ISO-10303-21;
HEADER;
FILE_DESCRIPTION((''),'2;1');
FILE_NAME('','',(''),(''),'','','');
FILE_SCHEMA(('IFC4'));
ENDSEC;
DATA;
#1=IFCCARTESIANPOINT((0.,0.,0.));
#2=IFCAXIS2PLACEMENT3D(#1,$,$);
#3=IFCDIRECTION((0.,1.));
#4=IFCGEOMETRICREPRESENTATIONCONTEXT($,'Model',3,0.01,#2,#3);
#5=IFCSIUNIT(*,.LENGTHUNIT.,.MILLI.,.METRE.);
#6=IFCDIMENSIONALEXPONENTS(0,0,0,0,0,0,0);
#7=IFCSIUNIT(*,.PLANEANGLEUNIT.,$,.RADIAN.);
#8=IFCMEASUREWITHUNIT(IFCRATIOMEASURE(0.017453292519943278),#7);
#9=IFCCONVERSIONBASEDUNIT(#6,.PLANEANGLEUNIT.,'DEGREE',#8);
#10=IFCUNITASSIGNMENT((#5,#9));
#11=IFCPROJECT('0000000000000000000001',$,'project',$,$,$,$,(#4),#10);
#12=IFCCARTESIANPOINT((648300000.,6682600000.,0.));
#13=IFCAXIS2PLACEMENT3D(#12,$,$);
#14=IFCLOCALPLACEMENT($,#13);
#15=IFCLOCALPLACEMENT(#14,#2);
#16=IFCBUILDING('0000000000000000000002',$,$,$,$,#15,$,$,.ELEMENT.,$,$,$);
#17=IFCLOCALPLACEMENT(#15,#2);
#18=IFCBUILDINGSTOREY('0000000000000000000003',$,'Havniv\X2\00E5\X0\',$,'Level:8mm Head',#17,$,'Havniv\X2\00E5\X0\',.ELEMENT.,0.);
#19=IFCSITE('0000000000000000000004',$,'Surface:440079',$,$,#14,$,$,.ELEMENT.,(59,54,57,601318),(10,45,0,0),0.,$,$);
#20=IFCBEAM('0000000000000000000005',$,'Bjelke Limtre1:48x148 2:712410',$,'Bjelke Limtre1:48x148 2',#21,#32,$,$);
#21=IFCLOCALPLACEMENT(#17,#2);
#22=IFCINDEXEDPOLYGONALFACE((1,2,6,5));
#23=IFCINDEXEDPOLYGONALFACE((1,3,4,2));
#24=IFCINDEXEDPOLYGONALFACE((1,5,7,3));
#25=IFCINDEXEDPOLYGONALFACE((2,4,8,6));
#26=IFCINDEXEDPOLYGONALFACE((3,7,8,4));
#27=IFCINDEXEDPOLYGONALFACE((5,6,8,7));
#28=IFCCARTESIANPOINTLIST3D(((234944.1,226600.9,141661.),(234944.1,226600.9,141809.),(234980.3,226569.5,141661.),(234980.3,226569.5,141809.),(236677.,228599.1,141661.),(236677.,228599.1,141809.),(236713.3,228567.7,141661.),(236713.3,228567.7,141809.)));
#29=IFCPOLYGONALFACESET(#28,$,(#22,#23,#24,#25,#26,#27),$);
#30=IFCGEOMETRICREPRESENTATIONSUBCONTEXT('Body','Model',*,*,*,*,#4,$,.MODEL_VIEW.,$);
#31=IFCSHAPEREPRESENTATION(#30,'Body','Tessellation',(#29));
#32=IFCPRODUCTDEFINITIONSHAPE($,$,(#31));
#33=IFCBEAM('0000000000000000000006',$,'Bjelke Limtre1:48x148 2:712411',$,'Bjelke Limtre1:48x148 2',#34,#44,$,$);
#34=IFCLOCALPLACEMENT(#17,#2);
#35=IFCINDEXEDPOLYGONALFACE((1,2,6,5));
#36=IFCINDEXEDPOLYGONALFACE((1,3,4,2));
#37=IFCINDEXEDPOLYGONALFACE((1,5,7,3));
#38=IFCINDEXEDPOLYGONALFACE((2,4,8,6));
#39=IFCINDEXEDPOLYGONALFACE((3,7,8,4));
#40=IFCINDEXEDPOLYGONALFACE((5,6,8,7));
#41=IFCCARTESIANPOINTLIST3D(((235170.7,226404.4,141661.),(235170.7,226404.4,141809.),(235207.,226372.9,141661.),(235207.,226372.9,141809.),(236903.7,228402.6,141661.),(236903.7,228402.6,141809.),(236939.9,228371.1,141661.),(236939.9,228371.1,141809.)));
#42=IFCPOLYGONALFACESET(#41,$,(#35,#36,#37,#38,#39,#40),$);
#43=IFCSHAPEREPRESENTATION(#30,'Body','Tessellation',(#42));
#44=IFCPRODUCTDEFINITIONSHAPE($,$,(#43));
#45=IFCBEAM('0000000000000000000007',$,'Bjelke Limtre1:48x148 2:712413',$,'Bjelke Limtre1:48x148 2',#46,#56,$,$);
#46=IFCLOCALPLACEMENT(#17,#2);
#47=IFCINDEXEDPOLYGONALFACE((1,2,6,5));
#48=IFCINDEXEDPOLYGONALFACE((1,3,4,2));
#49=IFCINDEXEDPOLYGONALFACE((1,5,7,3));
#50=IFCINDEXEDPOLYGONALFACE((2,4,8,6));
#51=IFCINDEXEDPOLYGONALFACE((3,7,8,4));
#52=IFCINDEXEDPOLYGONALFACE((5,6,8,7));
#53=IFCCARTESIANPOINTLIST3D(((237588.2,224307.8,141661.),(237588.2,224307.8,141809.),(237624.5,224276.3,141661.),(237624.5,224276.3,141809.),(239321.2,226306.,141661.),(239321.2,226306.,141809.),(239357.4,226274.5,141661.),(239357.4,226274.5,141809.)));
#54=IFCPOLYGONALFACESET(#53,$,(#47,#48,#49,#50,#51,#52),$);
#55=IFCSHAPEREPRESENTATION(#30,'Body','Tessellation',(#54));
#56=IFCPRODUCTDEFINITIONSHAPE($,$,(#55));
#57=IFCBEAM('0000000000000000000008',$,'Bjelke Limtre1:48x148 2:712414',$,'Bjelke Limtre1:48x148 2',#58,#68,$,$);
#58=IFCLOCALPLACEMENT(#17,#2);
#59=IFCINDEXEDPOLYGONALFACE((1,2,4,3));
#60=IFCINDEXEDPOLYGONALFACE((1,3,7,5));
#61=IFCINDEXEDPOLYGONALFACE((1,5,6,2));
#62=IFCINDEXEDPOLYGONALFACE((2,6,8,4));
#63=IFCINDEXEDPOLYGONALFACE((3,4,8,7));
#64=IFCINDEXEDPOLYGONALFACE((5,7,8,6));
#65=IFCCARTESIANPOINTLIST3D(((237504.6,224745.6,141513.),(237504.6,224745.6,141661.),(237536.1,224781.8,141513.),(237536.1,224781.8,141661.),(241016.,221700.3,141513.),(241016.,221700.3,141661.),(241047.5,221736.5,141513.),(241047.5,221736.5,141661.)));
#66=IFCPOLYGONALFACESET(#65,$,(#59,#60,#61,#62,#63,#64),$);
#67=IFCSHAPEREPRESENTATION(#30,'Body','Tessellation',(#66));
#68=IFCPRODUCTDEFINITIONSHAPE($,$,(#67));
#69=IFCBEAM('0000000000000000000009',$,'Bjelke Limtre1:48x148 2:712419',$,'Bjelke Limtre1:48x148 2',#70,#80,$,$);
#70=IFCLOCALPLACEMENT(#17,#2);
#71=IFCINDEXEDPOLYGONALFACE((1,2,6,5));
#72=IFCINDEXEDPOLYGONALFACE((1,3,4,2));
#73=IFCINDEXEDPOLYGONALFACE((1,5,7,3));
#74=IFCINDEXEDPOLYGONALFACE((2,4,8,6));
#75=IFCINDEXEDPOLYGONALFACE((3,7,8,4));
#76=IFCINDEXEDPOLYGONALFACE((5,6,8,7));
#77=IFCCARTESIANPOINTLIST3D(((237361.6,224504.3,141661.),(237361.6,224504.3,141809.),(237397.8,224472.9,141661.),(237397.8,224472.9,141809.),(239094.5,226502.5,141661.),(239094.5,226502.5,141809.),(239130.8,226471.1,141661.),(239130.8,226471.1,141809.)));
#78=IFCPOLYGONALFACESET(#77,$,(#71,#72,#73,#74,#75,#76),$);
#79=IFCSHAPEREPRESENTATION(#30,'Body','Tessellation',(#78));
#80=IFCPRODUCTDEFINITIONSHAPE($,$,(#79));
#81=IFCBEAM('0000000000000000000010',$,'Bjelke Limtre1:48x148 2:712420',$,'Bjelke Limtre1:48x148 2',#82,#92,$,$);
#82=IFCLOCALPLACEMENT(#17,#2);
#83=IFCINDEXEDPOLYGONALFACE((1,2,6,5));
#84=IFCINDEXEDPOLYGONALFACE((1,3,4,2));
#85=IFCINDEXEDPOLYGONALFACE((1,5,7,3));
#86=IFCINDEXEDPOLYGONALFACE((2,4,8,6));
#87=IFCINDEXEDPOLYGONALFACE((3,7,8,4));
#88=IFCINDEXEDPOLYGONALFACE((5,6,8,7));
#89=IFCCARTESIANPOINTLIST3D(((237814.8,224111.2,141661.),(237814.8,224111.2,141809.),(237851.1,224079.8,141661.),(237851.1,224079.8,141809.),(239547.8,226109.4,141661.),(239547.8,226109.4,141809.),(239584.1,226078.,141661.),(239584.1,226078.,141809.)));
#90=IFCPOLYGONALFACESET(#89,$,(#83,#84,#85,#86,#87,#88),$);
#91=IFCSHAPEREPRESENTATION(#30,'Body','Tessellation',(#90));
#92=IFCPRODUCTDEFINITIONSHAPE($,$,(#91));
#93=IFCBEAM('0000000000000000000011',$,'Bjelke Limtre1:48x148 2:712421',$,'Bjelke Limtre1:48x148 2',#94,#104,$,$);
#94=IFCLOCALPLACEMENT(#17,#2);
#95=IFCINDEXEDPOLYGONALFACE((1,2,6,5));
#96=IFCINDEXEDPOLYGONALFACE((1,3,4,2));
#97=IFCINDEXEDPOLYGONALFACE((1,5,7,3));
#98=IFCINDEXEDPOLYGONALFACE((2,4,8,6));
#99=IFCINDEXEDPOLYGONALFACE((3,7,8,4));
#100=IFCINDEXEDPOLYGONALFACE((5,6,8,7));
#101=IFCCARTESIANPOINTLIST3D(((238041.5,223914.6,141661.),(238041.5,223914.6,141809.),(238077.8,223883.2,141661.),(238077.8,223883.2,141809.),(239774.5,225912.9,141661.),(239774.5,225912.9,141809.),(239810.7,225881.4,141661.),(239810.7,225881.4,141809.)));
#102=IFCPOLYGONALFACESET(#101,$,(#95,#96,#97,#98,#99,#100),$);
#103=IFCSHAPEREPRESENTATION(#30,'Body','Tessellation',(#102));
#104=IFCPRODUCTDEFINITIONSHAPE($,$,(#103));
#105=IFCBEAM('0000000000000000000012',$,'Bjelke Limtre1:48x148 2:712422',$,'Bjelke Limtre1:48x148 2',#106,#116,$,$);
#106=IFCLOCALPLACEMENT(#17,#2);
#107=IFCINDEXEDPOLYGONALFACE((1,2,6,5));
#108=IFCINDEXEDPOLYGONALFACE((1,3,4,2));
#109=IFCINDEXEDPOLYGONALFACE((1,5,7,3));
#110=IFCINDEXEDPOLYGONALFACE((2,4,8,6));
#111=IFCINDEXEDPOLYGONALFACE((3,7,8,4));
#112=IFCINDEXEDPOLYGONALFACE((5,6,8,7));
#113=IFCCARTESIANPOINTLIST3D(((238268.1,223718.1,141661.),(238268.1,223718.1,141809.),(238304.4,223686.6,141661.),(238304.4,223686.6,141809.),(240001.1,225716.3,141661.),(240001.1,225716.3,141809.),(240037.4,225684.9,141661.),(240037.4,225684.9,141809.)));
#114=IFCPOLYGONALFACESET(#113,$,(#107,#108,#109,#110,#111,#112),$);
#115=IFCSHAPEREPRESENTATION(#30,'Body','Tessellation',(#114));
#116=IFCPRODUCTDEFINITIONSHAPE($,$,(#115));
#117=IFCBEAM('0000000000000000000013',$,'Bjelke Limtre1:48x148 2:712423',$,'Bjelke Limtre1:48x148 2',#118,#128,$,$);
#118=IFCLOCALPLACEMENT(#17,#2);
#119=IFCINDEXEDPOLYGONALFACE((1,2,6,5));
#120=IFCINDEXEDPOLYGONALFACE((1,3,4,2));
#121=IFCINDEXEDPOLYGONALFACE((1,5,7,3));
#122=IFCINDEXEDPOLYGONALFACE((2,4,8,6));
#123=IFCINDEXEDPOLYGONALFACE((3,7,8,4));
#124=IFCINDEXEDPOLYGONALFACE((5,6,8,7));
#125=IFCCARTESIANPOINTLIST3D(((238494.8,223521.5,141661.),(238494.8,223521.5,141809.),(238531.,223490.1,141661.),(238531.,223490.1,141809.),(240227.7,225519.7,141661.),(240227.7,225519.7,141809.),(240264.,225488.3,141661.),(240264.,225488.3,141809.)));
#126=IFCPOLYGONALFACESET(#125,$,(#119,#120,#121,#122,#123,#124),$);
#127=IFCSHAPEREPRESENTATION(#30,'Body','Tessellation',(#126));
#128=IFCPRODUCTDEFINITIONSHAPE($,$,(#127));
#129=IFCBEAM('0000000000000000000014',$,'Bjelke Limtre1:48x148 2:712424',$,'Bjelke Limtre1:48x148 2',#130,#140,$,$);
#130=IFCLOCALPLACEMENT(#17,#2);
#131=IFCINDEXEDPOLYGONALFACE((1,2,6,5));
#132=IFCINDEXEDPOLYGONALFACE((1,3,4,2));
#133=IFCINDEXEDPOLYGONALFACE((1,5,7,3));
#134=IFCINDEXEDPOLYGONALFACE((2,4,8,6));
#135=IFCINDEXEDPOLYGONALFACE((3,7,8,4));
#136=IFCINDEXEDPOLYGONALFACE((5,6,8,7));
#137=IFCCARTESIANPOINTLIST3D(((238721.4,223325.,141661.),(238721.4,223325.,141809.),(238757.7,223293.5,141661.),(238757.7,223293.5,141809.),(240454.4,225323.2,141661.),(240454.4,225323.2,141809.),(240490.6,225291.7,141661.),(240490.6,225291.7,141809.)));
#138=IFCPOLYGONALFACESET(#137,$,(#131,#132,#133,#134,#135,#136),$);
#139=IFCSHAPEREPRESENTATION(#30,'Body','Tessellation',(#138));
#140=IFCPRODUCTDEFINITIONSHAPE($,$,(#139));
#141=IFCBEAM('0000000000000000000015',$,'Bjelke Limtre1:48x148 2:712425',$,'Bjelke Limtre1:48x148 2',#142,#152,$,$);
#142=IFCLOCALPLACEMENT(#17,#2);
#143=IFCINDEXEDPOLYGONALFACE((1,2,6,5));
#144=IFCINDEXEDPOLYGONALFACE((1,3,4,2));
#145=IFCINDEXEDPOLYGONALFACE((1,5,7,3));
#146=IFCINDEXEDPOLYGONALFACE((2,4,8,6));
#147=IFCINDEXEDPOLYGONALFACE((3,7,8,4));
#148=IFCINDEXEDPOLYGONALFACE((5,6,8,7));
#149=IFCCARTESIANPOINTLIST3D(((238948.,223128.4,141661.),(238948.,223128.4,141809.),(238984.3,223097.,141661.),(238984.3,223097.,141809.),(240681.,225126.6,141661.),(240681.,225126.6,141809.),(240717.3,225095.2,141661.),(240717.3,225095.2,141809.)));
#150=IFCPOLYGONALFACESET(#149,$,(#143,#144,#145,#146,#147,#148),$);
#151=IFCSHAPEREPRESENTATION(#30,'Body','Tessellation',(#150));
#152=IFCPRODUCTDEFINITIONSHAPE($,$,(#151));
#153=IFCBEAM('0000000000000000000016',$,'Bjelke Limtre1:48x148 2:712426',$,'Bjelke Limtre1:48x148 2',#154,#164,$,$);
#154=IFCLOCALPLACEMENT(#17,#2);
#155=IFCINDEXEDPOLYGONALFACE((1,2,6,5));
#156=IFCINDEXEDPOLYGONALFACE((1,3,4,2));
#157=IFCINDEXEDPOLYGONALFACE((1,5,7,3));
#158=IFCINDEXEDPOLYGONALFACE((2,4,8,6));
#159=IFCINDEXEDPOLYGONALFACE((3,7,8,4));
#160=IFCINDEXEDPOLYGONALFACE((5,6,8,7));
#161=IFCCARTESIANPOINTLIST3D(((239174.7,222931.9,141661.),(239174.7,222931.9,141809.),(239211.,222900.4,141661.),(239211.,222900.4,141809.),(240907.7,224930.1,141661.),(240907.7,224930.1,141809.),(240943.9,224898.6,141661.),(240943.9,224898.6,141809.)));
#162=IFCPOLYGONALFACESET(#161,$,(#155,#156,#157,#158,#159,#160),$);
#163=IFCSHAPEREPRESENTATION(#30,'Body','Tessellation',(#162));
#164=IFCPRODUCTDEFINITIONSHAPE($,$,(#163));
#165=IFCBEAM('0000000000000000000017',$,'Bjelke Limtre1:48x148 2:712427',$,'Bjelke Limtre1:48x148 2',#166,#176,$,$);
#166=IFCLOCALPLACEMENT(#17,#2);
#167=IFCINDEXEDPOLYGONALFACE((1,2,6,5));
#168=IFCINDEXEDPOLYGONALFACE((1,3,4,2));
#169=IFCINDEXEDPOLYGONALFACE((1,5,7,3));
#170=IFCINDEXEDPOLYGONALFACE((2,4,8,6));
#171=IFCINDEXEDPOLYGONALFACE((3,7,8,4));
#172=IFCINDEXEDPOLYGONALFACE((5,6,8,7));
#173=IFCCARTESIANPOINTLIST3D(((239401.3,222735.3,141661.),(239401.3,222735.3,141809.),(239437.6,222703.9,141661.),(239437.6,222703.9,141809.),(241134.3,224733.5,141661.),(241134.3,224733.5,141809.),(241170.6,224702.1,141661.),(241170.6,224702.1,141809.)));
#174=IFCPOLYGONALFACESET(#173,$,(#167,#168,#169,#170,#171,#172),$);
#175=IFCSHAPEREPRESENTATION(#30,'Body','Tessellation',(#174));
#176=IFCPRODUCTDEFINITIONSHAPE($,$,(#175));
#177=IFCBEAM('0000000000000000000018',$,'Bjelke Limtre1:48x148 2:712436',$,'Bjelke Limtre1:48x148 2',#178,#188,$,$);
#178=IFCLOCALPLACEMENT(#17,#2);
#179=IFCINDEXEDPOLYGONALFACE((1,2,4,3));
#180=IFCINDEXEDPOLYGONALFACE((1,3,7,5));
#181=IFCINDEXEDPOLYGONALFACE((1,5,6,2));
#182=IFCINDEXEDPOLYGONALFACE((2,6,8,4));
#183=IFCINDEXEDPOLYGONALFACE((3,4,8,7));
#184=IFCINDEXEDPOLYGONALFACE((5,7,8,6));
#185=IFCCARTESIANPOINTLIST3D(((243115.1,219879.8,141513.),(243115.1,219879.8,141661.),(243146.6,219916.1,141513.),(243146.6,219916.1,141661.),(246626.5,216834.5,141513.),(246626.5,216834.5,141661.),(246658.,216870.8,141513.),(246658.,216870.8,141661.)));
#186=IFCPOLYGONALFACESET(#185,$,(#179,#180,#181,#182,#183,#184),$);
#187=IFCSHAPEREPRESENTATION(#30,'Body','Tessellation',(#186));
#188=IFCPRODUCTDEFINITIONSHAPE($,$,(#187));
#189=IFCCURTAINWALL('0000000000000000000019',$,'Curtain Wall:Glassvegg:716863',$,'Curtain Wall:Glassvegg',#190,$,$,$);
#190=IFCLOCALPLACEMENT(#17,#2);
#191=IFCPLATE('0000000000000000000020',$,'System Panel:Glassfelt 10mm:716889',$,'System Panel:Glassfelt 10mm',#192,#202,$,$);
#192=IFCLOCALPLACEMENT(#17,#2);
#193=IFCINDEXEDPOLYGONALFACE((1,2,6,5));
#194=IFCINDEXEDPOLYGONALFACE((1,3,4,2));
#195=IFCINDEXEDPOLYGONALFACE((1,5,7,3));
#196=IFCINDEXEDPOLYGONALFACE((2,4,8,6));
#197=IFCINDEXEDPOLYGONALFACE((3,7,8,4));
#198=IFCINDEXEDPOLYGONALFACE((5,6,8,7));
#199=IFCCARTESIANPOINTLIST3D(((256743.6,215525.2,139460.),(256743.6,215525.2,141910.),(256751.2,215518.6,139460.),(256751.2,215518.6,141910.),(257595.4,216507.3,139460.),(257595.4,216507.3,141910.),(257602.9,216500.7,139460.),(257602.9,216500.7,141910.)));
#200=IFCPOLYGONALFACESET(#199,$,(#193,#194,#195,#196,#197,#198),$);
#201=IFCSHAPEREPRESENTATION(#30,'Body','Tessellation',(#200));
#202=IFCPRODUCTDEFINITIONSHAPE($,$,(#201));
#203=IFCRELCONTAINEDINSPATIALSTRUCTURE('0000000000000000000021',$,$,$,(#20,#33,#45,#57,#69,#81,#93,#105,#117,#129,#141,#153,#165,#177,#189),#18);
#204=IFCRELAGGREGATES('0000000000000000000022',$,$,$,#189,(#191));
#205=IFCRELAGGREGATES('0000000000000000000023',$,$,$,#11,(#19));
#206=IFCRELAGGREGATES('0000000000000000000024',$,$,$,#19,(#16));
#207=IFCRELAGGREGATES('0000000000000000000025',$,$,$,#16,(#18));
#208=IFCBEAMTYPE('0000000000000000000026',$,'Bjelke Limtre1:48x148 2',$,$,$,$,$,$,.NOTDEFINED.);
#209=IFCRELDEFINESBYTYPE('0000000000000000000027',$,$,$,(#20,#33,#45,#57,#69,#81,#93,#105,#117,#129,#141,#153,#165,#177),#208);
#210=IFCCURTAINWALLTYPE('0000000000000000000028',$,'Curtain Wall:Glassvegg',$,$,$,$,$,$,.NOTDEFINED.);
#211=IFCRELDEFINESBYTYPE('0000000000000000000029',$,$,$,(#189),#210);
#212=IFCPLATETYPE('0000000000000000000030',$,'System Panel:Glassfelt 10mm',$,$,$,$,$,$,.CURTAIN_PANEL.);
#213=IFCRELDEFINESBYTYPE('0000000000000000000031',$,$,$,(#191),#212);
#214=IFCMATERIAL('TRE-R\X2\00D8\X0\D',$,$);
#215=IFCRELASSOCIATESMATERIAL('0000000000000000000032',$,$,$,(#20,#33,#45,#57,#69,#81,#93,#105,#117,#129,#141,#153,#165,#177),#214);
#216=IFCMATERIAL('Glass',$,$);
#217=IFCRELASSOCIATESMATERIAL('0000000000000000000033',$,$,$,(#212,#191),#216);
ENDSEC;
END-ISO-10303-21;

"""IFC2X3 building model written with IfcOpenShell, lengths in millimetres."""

from ifc_helpers import new_model, entity, si_unit, converted_unit, direction, frame, frame_2d, origin, origin_2d_with_axis, place, context, subcontext, project, spatial, rectangle, extrude, source, transform, mapped, material, type_object, type_shapes, element, aggregate, save


model = new_model("IFC2X3")

# Units and contexts
model_context = context("Model", 3, precision=0.01, world=origin(), true_north=direction((0.0, 1.0)))
body_context = subcontext(model_context, "Body", "Model", "MODEL_VIEW")
ifc_project = project(units=[si_unit("LENGTHUNIT", "METRE", prefix="MILLI"), converted_unit("PLANEANGLEUNIT", "DEGREE", entity("IfcRatioMeasure", 0.017453292519943278), si_unit("PLANEANGLEUNIT", "RADIAN"), dimensions=[0, 0, 0, 0, 0, 0, 0])], contexts=[model_context])

# Site, building, storey
site_placement = place(None, frame((648300000.0, 6682600000.0, 0.0)))
site = spatial("IfcSite", under=ifc_project, at=site_placement, Name="Surface:440079", CompositionType="ELEMENT", RefLatitude=(59, 54, 57, 601318), RefLongitude=(10, 45, 0, 0), RefElevation=0.0)
building_placement = place(site_placement, origin())
building = spatial("IfcBuilding", under=site, at=building_placement, CompositionType="ELEMENT")
storey_placement = place(building_placement, origin())
storey = spatial("IfcBuildingStorey", under=building, at=storey_placement, Name="Havnivå", ObjectType="Level:8mm Head", LongName="Havnivå", CompositionType="ELEMENT", Elevation=0.0)

# Beams
ifc_material_1 = material(Name="TRE-RØD")
beam_type = type_object("IfcBeamType", Name="Bjelke Limtre1:48x148 2", PredefinedType="NOTDEFINED")
beam_1_placement = place(storey_placement, frame((236695.2, 228583.4, 141809.0), z_axis=(0.0, 0.0, 1.0), x_axis=(-0.655187, -0.755467, 0.0)))
element("IfcBeam", 1, at=beam_1_placement, inside=storey, type_object=beam_type, material=ifc_material_1, Name="Bjelke Limtre1:48x148 2:712410", ObjectType="Bjelke Limtre1:48x148 2", context=body_context, shape_type="SweptSolid", body=[
    extrude(rectangle(XDim=148.0, YDim=48.0, at=frame_2d((0.0, 0.0), x_axis=(1.0, 0.0))), frame((0.0, 0.0, -74.0), z_axis=(1.0, 0.0, 0.0), x_axis=(0.0, 0.0, -1.0)), (0.0, 0.0, 1.0), 2645.0),
])
beam_2_placement = place(storey_placement, frame((236921.8, 228386.8, 141809.0), z_axis=(0.0, 0.0, 1.0), x_axis=(-0.655187, -0.755467, 0.0)))
element("IfcBeam", 2, at=beam_2_placement, inside=storey, type_object=beam_type, material=ifc_material_1, Name="Bjelke Limtre1:48x148 2:712411", ObjectType="Bjelke Limtre1:48x148 2", context=body_context, shape_type="SweptSolid", body=[
    extrude(rectangle(XDim=148.0, YDim=48.0, at=origin_2d_with_axis()), frame((0.0, 0.0, -74.0), z_axis=(1.0, 0.0, 0.0), x_axis=(0.0, 0.0, -1.0)), (0.0, 0.0, 1.0), 2645.0),
])
beam_3_placement = place(storey_placement, frame((239339.3, 226290.2, 141809.0), z_axis=(0.0, 0.0, 1.0), x_axis=(-0.655187, -0.755467, 0.0)))
element("IfcBeam", 3, at=beam_3_placement, inside=storey, type_object=beam_type, material=ifc_material_1, Name="Bjelke Limtre1:48x148 2:712413", ObjectType="Bjelke Limtre1:48x148 2", context=body_context, shape_type="SweptSolid", body=[
    extrude(rectangle(XDim=148.0, YDim=48.0, at=frame_2d((0.0, 0.0), x_axis=(1.0, 0.0))), frame((0.0, 0.0, -74.0), z_axis=(1.0, 0.0, 0.0), x_axis=(0.0, 0.0, -1.0)), (0.0, 0.0, 1.0), 2645.0),
])
beam_4_placement = place(storey_placement, frame((237520.4, 224763.7, 141661.0), z_axis=(0.0, 0.0, 1.0), x_axis=(0.755467, -0.655187, 0.0)))
element("IfcBeam", 4, at=beam_4_placement, inside=storey, type_object=beam_type, material=ifc_material_1, Name="Bjelke Limtre1:48x148 2:712414", ObjectType="Bjelke Limtre1:48x148 2", context=body_context, shape_type="SweptSolid", body=[
    extrude(rectangle(XDim=148.0, YDim=48.0, at=frame_2d((0.0, 0.0), x_axis=(1.0, 0.0))), frame((0.0, 0.0, -74.0), z_axis=(1.0, 0.0, 0.0), x_axis=(0.0, 0.0, -1.0)), (0.0, 0.0, 1.0), 4648.0),
])
for number, where, z_axis, x_axis, name in (
    (5, (239112.7, 226486.8, 141809.0), (0.0, 0.0, 1.0), (-0.655187, -0.755467, 0.0), "Bjelke Limtre1:48x148 2:712419"),
    (6, (239566.0, 226093.7, 141809.0), (0.0, 0.0, 1.0), (-0.655187, -0.755467, 0.0), "Bjelke Limtre1:48x148 2:712420"),
    (7, (239792.6, 225897.1, 141809.0), (0.0, 0.0, 1.0), (-0.655187, -0.755467, 0.0), "Bjelke Limtre1:48x148 2:712421"),
    (8, (240019.2, 225700.6, 141809.0), (0.0, 0.0, 1.0), (-0.655187, -0.755467, 0.0), "Bjelke Limtre1:48x148 2:712422"),
    (9, (240245.9, 225504.0, 141809.0), (0.0, 0.0, 1.0), (-0.655187, -0.755467, 0.0), "Bjelke Limtre1:48x148 2:712423"),
):
    element("IfcBeam", number, at=place(storey_placement, frame(where, z_axis=z_axis, x_axis=x_axis)), inside=storey, type_object=beam_type, material=ifc_material_1, Name=name, ObjectType="Bjelke Limtre1:48x148 2", context=body_context, shape_type="SweptSolid", body=[
        extrude(rectangle(XDim=148.0, YDim=48.0, at=origin_2d_with_axis()), frame((0.0, 0.0, -74.0), z_axis=(1.0, 0.0, 0.0), x_axis=(0.0, 0.0, -1.0)), (0.0, 0.0, 1.0), 2645.0),
    ])
for number, where, z_axis, x_axis, name in (
    (10, (240472.5, 225307.5, 141809.0), (0.0, 0.0, 1.0), (-0.655187, -0.755467, 0.0), "Bjelke Limtre1:48x148 2:712424"),
    (11, (240699.2, 225110.9, 141809.0), (0.0, 0.0, 1.0), (-0.655187, -0.755467, 0.0), "Bjelke Limtre1:48x148 2:712425"),
):
    element("IfcBeam", number, at=place(storey_placement, frame(where, z_axis=z_axis, x_axis=x_axis)), inside=storey, type_object=beam_type, material=ifc_material_1, Name=name, ObjectType="Bjelke Limtre1:48x148 2", context=body_context, shape_type="SweptSolid", body=[
        extrude(rectangle(XDim=148.0, YDim=48.0, at=frame_2d((0.0, 0.0), x_axis=(1.0, 0.0))), frame((0.0, 0.0, -74.0), z_axis=(1.0, 0.0, 0.0), x_axis=(0.0, 0.0, -1.0)), (0.0, 0.0, 1.0), 2645.0),
    ])
beam_5_placement = place(storey_placement, frame((240925.8, 224914.4, 141809.0), z_axis=(0.0, 0.0, 1.0), x_axis=(-0.655187, -0.755467, 0.0)))
element("IfcBeam", 12, at=beam_5_placement, inside=storey, type_object=beam_type, material=ifc_material_1, Name="Bjelke Limtre1:48x148 2:712426", ObjectType="Bjelke Limtre1:48x148 2", context=body_context, shape_type="SweptSolid", body=[
    extrude(rectangle(XDim=148.0, YDim=48.0, at=origin_2d_with_axis()), frame((0.0, 0.0, -74.0), z_axis=(1.0, 0.0, 0.0), x_axis=(0.0, 0.0, -1.0)), (0.0, 0.0, 1.0), 2645.0),
])
beam_6_placement = place(storey_placement, frame((241152.4, 224717.8, 141809.0), z_axis=(0.0, 0.0, 1.0), x_axis=(-0.655187, -0.755467, 0.0)))
element("IfcBeam", 13, at=beam_6_placement, inside=storey, type_object=beam_type, material=ifc_material_1, Name="Bjelke Limtre1:48x148 2:712427", ObjectType="Bjelke Limtre1:48x148 2", context=body_context, shape_type="SweptSolid", body=[
    extrude(rectangle(XDim=148.0, YDim=48.0, at=frame_2d((0.0, 0.0), x_axis=(1.0, 0.0))), frame((0.0, 0.0, -74.0), z_axis=(1.0, 0.0, 0.0), x_axis=(0.0, 0.0, -1.0)), (0.0, 0.0, 1.0), 2645.0),
])
beam_7_placement = place(storey_placement, frame((243130.8, 219898.0, 141661.0), z_axis=(0.0, 0.0, 1.0), x_axis=(0.755467, -0.655187, 0.0)))
element("IfcBeam", 14, at=beam_7_placement, inside=storey, type_object=beam_type, material=ifc_material_1, Name="Bjelke Limtre1:48x148 2:712436", ObjectType="Bjelke Limtre1:48x148 2", context=body_context, shape_type="SweptSolid", body=[
    extrude(rectangle(XDim=148.0, YDim=48.0, at=frame_2d((0.0, 0.0), x_axis=(1.0, 0.0))), frame((0.0, 0.0, -74.0), z_axis=(1.0, 0.0, 0.0), x_axis=(0.0, 0.0, -1.0)), (0.0, 0.0, 1.0), 4648.0),
])

# Curtain wall, plate
curtain_wall_type = type_object("IfcCurtainWallType", Name="Curtain Wall:Glassvegg", PredefinedType="NOTDEFINED")
curtain_wall_1_placement = place(storey_placement, origin())
curtain_wall_1 = element("IfcCurtainWall", 15, at=curtain_wall_1_placement, inside=storey, type_object=curtain_wall_type, Name="Curtain Wall:Glassvegg:716863", ObjectType="Curtain Wall:Glassvegg")
ifc_material_2 = material(Name="Glass")
plate_type_1 = type_object("IfcPlateType", Name="System Panel:Glassfelt 10mm", PredefinedType="CURTAIN_PANEL", material=ifc_material_2)
shared_shape_1 = source(origin(), body_context, "Body", "SweptSolid", [
    extrude(rectangle(XDim=10.0, YDim=1300.0, at=frame_2d((0.0, 0.0), x_axis=(1.0, 0.0))), frame((0.0, 10.0, 0.0), z_axis=(0.0, 0.0, 1.0), x_axis=(0.0, 1.0, 0.0)), (0.0, 0.0, 1.0), 2450.0),
])
type_shapes(plate_type_1, [shared_shape_1])
plate_1_placement = place(curtain_wall_1_placement, frame((257165.7, 216019.5, 139460.0), z_axis=(0.0, 0.0, 1.0), x_axis=(-0.655187, -0.755467, 0.0)))
plate_1 = element("IfcPlate", 16, at=plate_1_placement, type_object=plate_type_1, material=ifc_material_2, Name="System Panel:Glassfelt 10mm:716889", ObjectType="System Panel:Glassfelt 10mm", context=body_context, shape_type="MappedRepresentation", body=[
    mapped(shared_shape_1, transform((0.0, 0.0, 0.0), scale=1.0)),
])
aggregate(curtain_wall_1, [plate_1])

save(model, "model.ifc")
